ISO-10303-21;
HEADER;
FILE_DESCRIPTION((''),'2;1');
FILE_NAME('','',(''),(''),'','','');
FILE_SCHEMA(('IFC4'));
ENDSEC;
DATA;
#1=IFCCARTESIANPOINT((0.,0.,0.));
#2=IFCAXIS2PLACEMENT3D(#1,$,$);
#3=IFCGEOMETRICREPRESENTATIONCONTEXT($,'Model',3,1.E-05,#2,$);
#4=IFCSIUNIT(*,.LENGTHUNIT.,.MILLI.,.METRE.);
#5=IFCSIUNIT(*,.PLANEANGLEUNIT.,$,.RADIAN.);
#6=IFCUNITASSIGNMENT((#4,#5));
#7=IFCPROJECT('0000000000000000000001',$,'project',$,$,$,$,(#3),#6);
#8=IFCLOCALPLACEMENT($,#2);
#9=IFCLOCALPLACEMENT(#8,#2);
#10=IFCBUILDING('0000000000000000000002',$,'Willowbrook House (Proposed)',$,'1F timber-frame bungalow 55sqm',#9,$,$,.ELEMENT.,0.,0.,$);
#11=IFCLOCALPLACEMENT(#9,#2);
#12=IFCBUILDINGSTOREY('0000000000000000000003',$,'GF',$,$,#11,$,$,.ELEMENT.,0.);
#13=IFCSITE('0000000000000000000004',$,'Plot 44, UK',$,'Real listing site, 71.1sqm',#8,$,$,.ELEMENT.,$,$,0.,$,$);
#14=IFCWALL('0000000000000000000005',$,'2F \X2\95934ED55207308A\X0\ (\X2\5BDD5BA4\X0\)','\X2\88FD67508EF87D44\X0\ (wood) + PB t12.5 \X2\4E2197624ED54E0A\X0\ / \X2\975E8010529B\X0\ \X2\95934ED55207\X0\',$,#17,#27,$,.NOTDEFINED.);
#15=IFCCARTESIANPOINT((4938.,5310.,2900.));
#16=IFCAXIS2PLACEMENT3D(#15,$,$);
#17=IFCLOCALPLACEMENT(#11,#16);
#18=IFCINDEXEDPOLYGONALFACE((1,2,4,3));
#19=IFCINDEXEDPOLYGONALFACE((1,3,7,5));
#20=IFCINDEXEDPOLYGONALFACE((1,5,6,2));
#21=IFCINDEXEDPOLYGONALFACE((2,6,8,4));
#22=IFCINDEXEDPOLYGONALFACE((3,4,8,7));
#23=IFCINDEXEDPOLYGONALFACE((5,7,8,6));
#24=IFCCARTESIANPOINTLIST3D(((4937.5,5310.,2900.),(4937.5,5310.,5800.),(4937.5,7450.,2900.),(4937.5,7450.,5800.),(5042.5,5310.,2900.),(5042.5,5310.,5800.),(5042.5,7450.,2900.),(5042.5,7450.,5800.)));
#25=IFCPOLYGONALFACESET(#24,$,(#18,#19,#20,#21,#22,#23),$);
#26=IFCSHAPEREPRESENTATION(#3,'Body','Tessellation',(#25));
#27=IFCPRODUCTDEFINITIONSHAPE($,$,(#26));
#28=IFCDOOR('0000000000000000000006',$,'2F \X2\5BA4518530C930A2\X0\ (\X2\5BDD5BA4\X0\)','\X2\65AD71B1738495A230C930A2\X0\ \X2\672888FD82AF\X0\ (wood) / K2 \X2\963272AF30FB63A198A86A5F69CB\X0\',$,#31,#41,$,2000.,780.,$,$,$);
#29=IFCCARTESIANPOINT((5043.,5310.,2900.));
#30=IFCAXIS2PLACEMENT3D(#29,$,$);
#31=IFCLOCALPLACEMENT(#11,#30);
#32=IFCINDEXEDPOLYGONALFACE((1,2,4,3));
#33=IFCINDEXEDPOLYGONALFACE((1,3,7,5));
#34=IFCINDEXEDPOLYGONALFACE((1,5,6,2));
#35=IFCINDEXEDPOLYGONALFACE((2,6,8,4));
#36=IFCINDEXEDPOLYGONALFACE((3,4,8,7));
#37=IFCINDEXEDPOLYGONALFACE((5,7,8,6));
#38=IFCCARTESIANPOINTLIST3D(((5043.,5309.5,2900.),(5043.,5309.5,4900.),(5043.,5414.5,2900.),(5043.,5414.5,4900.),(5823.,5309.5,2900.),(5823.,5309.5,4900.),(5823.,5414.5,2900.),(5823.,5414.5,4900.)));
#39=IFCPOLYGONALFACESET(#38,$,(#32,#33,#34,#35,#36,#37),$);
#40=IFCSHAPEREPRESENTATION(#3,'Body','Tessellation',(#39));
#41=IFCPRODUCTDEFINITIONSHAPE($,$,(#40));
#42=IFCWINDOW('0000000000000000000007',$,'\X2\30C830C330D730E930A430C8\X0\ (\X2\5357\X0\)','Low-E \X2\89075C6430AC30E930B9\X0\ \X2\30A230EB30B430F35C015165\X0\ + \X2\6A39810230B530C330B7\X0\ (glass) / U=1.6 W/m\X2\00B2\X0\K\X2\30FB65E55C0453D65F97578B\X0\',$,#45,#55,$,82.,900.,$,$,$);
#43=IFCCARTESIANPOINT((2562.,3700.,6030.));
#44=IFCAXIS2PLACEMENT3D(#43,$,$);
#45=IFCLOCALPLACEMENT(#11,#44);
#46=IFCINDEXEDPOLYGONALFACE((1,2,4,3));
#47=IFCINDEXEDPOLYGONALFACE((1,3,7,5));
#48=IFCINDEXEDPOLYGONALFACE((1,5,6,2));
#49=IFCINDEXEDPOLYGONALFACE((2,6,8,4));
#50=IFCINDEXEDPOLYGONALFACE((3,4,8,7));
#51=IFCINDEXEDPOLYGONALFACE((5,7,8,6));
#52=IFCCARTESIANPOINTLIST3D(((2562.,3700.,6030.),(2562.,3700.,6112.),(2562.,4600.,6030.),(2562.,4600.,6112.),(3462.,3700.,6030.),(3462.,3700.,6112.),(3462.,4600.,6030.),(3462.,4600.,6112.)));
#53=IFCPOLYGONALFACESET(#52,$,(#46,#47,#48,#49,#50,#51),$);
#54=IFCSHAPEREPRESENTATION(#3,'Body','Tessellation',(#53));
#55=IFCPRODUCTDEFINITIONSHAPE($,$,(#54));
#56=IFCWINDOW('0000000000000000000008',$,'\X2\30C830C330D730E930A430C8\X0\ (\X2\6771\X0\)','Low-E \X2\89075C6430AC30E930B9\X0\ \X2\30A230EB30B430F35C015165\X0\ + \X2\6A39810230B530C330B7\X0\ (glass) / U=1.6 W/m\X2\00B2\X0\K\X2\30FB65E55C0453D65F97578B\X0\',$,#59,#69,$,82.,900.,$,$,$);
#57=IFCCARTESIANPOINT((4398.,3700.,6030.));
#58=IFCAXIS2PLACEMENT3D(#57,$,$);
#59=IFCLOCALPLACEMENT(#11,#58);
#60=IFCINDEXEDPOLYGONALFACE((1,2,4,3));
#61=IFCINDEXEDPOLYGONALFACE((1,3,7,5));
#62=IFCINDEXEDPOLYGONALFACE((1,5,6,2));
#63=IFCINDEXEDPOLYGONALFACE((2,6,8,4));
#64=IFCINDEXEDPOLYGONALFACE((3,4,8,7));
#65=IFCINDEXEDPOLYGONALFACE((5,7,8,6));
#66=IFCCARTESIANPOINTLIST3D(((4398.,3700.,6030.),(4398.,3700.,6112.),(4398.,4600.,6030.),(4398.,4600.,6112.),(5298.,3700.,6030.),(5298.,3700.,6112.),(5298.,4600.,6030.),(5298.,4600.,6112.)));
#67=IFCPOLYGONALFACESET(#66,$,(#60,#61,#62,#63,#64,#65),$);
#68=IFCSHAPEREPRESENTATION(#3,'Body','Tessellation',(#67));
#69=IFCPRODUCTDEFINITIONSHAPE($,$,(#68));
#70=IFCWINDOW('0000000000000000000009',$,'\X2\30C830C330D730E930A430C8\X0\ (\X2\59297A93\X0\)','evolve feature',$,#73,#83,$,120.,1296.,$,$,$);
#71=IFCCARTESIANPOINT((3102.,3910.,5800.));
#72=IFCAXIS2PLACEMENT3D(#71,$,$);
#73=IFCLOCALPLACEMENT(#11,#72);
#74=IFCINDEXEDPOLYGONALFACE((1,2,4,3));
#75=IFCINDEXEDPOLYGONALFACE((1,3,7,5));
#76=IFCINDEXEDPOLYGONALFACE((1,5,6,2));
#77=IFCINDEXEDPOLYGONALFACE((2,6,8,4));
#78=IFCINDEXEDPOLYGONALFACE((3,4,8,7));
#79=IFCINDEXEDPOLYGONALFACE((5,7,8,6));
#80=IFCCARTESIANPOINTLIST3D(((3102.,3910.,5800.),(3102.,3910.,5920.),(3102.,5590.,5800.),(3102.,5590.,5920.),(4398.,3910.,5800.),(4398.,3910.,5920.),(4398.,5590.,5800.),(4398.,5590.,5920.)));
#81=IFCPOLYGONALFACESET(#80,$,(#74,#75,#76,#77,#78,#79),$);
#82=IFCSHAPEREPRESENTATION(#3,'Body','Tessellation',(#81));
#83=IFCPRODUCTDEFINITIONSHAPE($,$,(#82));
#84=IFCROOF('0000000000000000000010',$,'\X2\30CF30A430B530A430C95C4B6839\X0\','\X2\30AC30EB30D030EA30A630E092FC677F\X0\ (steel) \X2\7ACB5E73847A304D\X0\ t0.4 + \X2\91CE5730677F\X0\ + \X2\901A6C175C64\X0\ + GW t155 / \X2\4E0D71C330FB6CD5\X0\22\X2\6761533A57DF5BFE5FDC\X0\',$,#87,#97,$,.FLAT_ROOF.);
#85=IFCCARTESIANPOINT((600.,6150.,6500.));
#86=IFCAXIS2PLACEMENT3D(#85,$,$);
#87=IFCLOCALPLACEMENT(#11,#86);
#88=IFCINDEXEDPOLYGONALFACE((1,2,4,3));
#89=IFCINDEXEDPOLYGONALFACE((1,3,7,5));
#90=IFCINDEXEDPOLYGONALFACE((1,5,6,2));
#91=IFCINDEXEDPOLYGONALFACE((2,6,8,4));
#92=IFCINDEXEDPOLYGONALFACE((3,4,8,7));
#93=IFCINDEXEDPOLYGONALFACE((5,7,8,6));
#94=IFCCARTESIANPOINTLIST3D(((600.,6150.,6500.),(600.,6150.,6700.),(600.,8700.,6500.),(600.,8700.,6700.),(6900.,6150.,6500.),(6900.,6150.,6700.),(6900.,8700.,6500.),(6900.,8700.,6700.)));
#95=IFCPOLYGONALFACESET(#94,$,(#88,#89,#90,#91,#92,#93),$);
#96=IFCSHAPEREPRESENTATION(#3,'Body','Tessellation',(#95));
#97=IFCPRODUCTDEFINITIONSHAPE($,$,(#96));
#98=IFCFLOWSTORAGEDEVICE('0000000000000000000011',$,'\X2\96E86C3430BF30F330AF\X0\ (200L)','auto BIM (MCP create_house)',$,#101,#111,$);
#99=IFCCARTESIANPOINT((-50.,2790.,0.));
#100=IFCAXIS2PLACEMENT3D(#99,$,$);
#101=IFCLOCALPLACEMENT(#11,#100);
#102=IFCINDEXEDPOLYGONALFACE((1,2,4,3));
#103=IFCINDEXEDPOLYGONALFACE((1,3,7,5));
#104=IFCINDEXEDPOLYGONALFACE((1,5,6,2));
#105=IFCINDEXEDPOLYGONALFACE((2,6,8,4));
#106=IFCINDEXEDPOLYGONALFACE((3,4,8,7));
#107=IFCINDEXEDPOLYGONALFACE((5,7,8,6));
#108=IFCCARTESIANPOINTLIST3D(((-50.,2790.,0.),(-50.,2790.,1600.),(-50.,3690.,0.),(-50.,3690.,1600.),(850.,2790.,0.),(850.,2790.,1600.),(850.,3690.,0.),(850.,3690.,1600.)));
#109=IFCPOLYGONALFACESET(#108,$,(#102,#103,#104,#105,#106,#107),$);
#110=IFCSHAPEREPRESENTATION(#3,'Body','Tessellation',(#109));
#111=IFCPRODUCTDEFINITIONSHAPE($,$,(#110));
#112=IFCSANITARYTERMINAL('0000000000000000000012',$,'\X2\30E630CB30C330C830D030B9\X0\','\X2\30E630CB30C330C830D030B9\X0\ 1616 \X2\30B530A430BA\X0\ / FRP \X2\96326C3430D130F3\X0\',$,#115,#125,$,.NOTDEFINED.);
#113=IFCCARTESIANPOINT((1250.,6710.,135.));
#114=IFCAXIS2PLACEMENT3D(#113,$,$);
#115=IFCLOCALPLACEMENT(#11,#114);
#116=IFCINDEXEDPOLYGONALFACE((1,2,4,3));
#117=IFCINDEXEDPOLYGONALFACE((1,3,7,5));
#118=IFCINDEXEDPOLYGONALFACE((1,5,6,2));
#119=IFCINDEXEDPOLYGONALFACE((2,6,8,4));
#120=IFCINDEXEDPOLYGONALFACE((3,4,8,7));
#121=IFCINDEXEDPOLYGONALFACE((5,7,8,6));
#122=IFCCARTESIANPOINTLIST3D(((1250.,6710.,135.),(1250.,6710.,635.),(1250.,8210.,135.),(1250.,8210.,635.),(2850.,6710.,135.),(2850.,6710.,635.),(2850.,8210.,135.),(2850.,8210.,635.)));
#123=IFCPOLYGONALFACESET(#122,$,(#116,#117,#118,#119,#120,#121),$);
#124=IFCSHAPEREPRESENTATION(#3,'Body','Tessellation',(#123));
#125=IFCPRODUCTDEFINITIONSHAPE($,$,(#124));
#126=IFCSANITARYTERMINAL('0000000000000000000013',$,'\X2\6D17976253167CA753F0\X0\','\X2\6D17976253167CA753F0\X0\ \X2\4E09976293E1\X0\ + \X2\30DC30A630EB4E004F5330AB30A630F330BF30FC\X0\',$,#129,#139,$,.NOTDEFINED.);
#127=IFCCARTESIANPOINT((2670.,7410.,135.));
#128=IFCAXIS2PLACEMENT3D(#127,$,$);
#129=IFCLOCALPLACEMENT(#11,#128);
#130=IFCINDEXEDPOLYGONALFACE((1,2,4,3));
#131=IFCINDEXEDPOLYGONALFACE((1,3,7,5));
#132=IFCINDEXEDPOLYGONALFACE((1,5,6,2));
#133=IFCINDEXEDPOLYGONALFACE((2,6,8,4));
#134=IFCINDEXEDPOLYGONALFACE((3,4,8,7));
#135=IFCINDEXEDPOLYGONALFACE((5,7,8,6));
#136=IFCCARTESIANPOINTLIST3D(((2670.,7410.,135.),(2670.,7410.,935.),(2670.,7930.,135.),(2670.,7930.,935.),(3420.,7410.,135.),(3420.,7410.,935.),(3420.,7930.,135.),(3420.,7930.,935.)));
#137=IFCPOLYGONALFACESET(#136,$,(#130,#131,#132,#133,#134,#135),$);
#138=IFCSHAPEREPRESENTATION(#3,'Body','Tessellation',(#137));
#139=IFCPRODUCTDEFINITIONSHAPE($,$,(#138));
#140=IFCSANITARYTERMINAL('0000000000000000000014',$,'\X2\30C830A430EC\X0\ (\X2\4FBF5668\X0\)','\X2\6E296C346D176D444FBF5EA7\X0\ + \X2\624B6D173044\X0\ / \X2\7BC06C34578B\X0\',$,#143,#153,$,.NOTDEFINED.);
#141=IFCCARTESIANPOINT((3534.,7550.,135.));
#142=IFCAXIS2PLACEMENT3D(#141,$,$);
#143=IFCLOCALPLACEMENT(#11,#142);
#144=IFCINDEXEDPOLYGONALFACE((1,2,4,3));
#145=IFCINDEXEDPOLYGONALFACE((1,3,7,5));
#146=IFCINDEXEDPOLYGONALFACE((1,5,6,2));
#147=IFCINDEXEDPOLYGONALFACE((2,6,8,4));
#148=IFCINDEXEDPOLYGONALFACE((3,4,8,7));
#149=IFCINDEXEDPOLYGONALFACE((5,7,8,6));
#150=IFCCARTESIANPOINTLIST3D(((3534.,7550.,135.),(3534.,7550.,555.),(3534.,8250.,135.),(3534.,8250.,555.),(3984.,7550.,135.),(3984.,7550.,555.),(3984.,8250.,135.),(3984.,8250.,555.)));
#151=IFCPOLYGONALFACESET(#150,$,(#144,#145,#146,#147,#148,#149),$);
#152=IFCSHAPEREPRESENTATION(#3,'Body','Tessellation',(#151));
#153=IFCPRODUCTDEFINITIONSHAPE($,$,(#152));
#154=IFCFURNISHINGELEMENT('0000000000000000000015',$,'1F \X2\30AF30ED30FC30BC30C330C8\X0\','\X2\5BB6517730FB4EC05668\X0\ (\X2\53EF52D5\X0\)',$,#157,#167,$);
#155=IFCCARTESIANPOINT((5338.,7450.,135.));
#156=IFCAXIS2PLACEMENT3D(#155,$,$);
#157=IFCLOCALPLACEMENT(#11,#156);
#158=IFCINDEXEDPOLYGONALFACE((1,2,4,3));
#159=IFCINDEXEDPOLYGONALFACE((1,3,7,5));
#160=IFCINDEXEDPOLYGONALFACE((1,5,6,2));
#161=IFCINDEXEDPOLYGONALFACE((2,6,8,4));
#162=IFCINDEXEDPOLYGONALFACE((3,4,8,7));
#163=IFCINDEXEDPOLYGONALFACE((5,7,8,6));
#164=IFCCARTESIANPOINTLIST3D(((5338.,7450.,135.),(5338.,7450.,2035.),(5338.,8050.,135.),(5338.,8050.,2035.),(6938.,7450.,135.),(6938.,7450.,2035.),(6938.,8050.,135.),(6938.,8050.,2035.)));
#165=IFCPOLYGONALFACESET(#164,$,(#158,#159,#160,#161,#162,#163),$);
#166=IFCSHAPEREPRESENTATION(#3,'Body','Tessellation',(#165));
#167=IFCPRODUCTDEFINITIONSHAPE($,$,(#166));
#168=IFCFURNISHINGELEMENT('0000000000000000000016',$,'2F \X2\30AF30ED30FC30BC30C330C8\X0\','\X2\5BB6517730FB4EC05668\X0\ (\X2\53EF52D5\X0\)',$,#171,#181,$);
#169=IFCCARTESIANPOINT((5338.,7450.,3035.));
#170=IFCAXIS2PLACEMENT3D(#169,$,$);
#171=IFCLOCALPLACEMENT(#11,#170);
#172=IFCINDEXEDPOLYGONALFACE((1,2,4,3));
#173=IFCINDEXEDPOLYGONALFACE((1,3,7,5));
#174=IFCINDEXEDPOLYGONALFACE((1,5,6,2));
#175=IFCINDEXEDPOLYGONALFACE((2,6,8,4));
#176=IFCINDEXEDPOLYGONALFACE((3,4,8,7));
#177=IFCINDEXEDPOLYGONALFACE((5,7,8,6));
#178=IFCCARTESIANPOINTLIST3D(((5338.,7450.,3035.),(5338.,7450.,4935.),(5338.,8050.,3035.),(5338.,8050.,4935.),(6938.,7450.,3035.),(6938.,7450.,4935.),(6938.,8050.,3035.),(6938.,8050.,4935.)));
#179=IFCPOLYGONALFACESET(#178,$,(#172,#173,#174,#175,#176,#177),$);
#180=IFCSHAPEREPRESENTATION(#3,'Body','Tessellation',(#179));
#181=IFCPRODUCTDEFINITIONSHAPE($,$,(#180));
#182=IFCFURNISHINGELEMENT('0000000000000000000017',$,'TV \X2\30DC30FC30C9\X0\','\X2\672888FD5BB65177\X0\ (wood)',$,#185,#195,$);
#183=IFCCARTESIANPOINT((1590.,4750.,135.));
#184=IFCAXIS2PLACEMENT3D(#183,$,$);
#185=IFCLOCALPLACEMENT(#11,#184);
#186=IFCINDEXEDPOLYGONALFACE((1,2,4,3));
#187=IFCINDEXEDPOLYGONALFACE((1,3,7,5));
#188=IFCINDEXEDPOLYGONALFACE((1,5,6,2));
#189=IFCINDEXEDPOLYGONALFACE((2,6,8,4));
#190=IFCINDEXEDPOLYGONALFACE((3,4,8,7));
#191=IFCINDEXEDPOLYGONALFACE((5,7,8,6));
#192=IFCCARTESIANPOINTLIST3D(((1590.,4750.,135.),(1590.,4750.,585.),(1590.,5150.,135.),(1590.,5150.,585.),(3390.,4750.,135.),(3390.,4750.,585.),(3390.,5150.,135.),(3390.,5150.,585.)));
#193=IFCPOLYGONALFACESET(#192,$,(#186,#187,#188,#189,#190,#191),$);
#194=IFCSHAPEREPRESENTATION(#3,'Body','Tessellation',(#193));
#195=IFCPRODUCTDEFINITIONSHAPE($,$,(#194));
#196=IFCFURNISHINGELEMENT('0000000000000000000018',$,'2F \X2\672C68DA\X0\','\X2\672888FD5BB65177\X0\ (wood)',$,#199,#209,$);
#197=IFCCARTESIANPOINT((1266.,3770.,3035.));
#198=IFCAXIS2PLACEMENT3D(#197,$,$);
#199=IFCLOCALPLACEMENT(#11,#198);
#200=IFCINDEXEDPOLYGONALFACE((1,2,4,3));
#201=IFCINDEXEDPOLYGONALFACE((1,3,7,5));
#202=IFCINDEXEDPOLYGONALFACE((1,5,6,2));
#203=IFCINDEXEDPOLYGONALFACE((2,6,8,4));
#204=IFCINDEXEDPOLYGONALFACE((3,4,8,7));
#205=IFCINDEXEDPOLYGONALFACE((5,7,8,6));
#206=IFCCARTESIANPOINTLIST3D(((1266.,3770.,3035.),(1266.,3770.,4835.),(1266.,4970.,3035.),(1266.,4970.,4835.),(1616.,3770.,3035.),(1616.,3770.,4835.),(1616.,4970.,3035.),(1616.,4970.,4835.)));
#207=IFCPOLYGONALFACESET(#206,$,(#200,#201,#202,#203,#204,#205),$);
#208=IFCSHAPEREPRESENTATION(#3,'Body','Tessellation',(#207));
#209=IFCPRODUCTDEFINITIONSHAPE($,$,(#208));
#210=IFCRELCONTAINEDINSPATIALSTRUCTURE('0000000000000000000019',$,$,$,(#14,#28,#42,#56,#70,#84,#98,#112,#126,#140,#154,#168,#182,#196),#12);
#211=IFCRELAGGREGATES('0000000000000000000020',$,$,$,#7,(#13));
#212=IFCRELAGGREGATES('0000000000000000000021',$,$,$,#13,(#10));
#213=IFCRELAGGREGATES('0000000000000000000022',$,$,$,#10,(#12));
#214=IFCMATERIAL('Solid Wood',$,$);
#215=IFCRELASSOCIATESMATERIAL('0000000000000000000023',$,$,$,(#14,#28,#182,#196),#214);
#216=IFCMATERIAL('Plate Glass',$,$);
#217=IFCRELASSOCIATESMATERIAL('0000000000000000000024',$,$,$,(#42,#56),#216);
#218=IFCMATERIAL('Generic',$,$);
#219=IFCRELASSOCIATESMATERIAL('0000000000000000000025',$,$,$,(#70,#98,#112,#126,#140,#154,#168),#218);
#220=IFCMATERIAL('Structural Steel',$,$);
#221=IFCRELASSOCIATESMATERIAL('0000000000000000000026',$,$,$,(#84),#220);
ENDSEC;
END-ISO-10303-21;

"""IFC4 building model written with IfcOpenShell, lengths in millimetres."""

from ifc_helpers import new_model, si_unit, frame, frame_2d, origin, place, context, project, spatial, rectangle, extrude, material, element, save


model = new_model("IFC4")

# Units and contexts
model_context = context("Model", 3, precision=1e-05, world=origin())
ifc_project = project(units=[si_unit("LENGTHUNIT", "METRE", prefix="MILLI"), si_unit("PLANEANGLEUNIT", "RADIAN")], contexts=[model_context])

# Site, building, storey
site_placement = place(None, origin())
site = spatial("IfcSite", under=ifc_project, at=site_placement, Name="Plot 44, UK", ObjectType="Real listing site, 71.1sqm", CompositionType="ELEMENT", RefElevation=0.0)
building_placement = place(site_placement, origin())
building = spatial("IfcBuilding", under=site, at=building_placement, Name="Willowbrook House (Proposed)", ObjectType="1F timber-frame bungalow 55sqm", CompositionType="ELEMENT", ElevationOfRefHeight=0.0, ElevationOfTerrain=0.0)
storey_placement = place(building_placement, origin())
storey = spatial("IfcBuildingStorey", under=building, at=storey_placement, Name="GF", CompositionType="ELEMENT", Elevation=0.0)

# Shared definitions
ifc_material_1 = material(Name="Solid Wood")
ifc_material_2 = material(Name="Plate Glass")

# Wall
wall_1_placement = place(storey_placement, frame((4938.0, 5310.0, 2900.0)))
element("IfcWall", 1, at=wall_1_placement, inside=storey, material=ifc_material_1, Name="2F 間仕切り (寝室)", Description="製材軸組 (wood) + PB t12.5 両面仕上 / 非耐力 間仕切", PredefinedType="NOTDEFINED", context=model_context, shape_type="SweptSolid", body=[
    extrude(rectangle(XDim=105.0, YDim=2140.0, at=frame_2d((52.0, 1070.0))), frame((4938.0, 5310.0, 2900.0)), (0.0, 0.0, 1.0), 2900.0),
])

# Door
door_1_placement = place(storey_placement, frame((5043.0, 5310.0, 2900.0)))
element("IfcDoor", 2, at=door_1_placement, inside=storey, material=ifc_material_1, Name="2F 室内ドア (寝室)", Description="断熱玄関ドア 木製芯 (wood) / K2 防犯・採風機構", OverallHeight=2000.0, OverallWidth=780.0, context=model_context, shape_type="SweptSolid", body=[
    extrude(rectangle(XDim=780.0, YDim=105.0, at=frame_2d((390.0, 52.0))), frame((5043.0, 5310.0, 2900.0)), (0.0, 0.0, 1.0), 2000.0),
])

# Windows
window_1_placement = place(storey_placement, frame((2562.0, 3700.0, 6030.0)))
element("IfcWindow", 3, at=window_1_placement, inside=storey, material=ifc_material_2, Name="トップライト (南)", Description="Low-E 複層ガラス アルゴン封入 + 樹脂サッシ (glass) / U=1.6 W/m²K・日射取得型", OverallHeight=82.0, OverallWidth=900.0, context=model_context, shape_type="SweptSolid", body=[
    extrude(rectangle(XDim=900.0, YDim=900.0, at=frame_2d((450.0, 450.0))), frame((2562.0, 3700.0, 6030.0)), (0.0, 0.0, 1.0), 82.0),
])
window_2_placement = place(storey_placement, frame((4398.0, 3700.0, 6030.0)))
element("IfcWindow", 4, at=window_2_placement, inside=storey, material=ifc_material_2, Name="トップライト (東)", Description="Low-E 複層ガラス アルゴン封入 + 樹脂サッシ (glass) / U=1.6 W/m²K・日射取得型", OverallHeight=82.0, OverallWidth=900.0, context=model_context, shape_type="SweptSolid", body=[
    extrude(rectangle(XDim=900.0, YDim=900.0, at=frame_2d((450.0, 450.0))), frame((4398.0, 3700.0, 6030.0)), (0.0, 0.0, 1.0), 82.0),
])
ifc_material_3 = material(Name="Generic")
window_3_placement = place(storey_placement, frame((3102.0, 3910.0, 5800.0)))
element("IfcWindow", 5, at=window_3_placement, inside=storey, material=ifc_material_3, Name="トップライト (天窓)", Description="evolve feature", OverallHeight=120.0, OverallWidth=1296.0, context=model_context, shape_type="SweptSolid", body=[
    extrude(rectangle(XDim=1296.0, YDim=1680.0, at=frame_2d((648.0, 840.0))), frame((3102.0, 3910.0, 5800.0)), (0.0, 0.0, 1.0), 120.0),
])

# Roof
ifc_material_4 = material(Name="Structural Steel")
roof_placement = place(storey_placement, frame((600.0, 6150.0, 6500.0)))
element("IfcRoof", 6, at=roof_placement, inside=storey, material=ifc_material_4, Name="ハイサイド屋根", Description="ガルバリウム鋼板 (steel) 立平葺き t0.4 + 野地板 + 通気層 + GW t155 / 不燃・法22条区域対応", PredefinedType="FLAT_ROOF", context=model_context, shape_type="SweptSolid", body=[
    extrude(rectangle(XDim=6300.0, YDim=2550.0, at=frame_2d((3150.0, 1275.0))), frame((600.0, 6150.0, 6500.0)), (0.0, 0.0, 1.0), 200.0),
])

# Flow storage device
flow_storage_device_placement = place(storey_placement, frame((-50.0, 2790.0, 0.0)))
element("IfcFlowStorageDevice", 7, at=flow_storage_device_placement, inside=storey, material=ifc_material_3, Name="雨水タンク (200L)", Description="auto BIM (MCP create_house)", context=model_context, shape_type="SweptSolid", body=[
    extrude(rectangle(XDim=900.0, YDim=900.0, at=frame_2d((450.0, 450.0))), frame((-50.0, 2790.0, 0.0)), (0.0, 0.0, 1.0), 1600.0),
])

# Sanitary terminals
sanitary_terminal_1_placement = place(storey_placement, frame((1250.0, 6710.0, 135.0)))
element("IfcSanitaryTerminal", 8, at=sanitary_terminal_1_placement, inside=storey, material=ifc_material_3, Name="ユニットバス", Description="ユニットバス 1616 サイズ / FRP 防水パン", PredefinedType="NOTDEFINED", context=model_context, shape_type="SweptSolid", body=[
    extrude(rectangle(XDim=1600.0, YDim=1500.0, at=frame_2d((800.0, 750.0))), frame((1250.0, 6710.0, 135.0)), (0.0, 0.0, 1.0), 500.0),
])
sanitary_terminal_2_placement = place(storey_placement, frame((2670.0, 7410.0, 135.0)))
element("IfcSanitaryTerminal", 9, at=sanitary_terminal_2_placement, inside=storey, material=ifc_material_3, Name="洗面化粧台", Description="洗面化粧台 三面鏡 + ボウル一体カウンター", PredefinedType="NOTDEFINED", context=model_context, shape_type="SweptSolid", body=[
    extrude(rectangle(XDim=750.0, YDim=520.0, at=frame_2d((375.0, 260.0))), frame((2670.0, 7410.0, 135.0)), (0.0, 0.0, 1.0), 800.0),
])
sanitary_terminal_3_placement = place(storey_placement, frame((3534.0, 7550.0, 135.0)))
element("IfcSanitaryTerminal", 10, at=sanitary_terminal_3_placement, inside=storey, material=ifc_material_3, Name="トイレ (便器)", Description="温水洗浄便座 + 手洗い / 節水型", PredefinedType="NOTDEFINED", context=model_context, shape_type="SweptSolid", body=[
    extrude(rectangle(XDim=450.0, YDim=700.0, at=frame_2d((225.0, 350.0))), frame((3534.0, 7550.0, 135.0)), (0.0, 0.0, 1.0), 420.0),
])

# Furnishing elements
furnishing_1_placement = place(storey_placement, frame((5338.0, 7450.0, 135.0)))
element("IfcFurnishingElement", 11, at=furnishing_1_placement, inside=storey, material=ifc_material_3, Name="1F クローゼット", Description="家具・什器 (可動)", context=model_context, shape_type="SweptSolid", body=[
    extrude(rectangle(XDim=1600.0, YDim=600.0, at=frame_2d((800.0, 300.0))), frame((5338.0, 7450.0, 135.0)), (0.0, 0.0, 1.0), 1900.0),
])
furnishing_2_placement = place(storey_placement, frame((5338.0, 7450.0, 3035.0)))
element("IfcFurnishingElement", 12, at=furnishing_2_placement, inside=storey, material=ifc_material_3, Name="2F クローゼット", Description="家具・什器 (可動)", context=model_context, shape_type="SweptSolid", body=[
    extrude(rectangle(XDim=1600.0, YDim=600.0, at=frame_2d((800.0, 300.0))), frame((5338.0, 7450.0, 3035.0)), (0.0, 0.0, 1.0), 1900.0),
])
furnishing_3_placement = place(storey_placement, frame((1590.0, 4750.0, 135.0)))
element("IfcFurnishingElement", 13, at=furnishing_3_placement, inside=storey, material=ifc_material_1, Name="TV ボード", Description="木製家具 (wood)", context=model_context, shape_type="SweptSolid", body=[
    extrude(rectangle(XDim=1800.0, YDim=400.0, at=frame_2d((900.0, 200.0))), frame((1590.0, 4750.0, 135.0)), (0.0, 0.0, 1.0), 450.0),
])
furnishing_4_placement = place(storey_placement, frame((1266.0, 3770.0, 3035.0)))
element("IfcFurnishingElement", 14, at=furnishing_4_placement, inside=storey, material=ifc_material_1, Name="2F 本棚", Description="木製家具 (wood)", context=model_context, shape_type="SweptSolid", body=[
    extrude(rectangle(XDim=350.0, YDim=1200.0, at=frame_2d((175.0, 600.0))), frame((1266.0, 3770.0, 3035.0)), (0.0, 0.0, 1.0), 1800.0),
])

save(model, "model.ifc")
